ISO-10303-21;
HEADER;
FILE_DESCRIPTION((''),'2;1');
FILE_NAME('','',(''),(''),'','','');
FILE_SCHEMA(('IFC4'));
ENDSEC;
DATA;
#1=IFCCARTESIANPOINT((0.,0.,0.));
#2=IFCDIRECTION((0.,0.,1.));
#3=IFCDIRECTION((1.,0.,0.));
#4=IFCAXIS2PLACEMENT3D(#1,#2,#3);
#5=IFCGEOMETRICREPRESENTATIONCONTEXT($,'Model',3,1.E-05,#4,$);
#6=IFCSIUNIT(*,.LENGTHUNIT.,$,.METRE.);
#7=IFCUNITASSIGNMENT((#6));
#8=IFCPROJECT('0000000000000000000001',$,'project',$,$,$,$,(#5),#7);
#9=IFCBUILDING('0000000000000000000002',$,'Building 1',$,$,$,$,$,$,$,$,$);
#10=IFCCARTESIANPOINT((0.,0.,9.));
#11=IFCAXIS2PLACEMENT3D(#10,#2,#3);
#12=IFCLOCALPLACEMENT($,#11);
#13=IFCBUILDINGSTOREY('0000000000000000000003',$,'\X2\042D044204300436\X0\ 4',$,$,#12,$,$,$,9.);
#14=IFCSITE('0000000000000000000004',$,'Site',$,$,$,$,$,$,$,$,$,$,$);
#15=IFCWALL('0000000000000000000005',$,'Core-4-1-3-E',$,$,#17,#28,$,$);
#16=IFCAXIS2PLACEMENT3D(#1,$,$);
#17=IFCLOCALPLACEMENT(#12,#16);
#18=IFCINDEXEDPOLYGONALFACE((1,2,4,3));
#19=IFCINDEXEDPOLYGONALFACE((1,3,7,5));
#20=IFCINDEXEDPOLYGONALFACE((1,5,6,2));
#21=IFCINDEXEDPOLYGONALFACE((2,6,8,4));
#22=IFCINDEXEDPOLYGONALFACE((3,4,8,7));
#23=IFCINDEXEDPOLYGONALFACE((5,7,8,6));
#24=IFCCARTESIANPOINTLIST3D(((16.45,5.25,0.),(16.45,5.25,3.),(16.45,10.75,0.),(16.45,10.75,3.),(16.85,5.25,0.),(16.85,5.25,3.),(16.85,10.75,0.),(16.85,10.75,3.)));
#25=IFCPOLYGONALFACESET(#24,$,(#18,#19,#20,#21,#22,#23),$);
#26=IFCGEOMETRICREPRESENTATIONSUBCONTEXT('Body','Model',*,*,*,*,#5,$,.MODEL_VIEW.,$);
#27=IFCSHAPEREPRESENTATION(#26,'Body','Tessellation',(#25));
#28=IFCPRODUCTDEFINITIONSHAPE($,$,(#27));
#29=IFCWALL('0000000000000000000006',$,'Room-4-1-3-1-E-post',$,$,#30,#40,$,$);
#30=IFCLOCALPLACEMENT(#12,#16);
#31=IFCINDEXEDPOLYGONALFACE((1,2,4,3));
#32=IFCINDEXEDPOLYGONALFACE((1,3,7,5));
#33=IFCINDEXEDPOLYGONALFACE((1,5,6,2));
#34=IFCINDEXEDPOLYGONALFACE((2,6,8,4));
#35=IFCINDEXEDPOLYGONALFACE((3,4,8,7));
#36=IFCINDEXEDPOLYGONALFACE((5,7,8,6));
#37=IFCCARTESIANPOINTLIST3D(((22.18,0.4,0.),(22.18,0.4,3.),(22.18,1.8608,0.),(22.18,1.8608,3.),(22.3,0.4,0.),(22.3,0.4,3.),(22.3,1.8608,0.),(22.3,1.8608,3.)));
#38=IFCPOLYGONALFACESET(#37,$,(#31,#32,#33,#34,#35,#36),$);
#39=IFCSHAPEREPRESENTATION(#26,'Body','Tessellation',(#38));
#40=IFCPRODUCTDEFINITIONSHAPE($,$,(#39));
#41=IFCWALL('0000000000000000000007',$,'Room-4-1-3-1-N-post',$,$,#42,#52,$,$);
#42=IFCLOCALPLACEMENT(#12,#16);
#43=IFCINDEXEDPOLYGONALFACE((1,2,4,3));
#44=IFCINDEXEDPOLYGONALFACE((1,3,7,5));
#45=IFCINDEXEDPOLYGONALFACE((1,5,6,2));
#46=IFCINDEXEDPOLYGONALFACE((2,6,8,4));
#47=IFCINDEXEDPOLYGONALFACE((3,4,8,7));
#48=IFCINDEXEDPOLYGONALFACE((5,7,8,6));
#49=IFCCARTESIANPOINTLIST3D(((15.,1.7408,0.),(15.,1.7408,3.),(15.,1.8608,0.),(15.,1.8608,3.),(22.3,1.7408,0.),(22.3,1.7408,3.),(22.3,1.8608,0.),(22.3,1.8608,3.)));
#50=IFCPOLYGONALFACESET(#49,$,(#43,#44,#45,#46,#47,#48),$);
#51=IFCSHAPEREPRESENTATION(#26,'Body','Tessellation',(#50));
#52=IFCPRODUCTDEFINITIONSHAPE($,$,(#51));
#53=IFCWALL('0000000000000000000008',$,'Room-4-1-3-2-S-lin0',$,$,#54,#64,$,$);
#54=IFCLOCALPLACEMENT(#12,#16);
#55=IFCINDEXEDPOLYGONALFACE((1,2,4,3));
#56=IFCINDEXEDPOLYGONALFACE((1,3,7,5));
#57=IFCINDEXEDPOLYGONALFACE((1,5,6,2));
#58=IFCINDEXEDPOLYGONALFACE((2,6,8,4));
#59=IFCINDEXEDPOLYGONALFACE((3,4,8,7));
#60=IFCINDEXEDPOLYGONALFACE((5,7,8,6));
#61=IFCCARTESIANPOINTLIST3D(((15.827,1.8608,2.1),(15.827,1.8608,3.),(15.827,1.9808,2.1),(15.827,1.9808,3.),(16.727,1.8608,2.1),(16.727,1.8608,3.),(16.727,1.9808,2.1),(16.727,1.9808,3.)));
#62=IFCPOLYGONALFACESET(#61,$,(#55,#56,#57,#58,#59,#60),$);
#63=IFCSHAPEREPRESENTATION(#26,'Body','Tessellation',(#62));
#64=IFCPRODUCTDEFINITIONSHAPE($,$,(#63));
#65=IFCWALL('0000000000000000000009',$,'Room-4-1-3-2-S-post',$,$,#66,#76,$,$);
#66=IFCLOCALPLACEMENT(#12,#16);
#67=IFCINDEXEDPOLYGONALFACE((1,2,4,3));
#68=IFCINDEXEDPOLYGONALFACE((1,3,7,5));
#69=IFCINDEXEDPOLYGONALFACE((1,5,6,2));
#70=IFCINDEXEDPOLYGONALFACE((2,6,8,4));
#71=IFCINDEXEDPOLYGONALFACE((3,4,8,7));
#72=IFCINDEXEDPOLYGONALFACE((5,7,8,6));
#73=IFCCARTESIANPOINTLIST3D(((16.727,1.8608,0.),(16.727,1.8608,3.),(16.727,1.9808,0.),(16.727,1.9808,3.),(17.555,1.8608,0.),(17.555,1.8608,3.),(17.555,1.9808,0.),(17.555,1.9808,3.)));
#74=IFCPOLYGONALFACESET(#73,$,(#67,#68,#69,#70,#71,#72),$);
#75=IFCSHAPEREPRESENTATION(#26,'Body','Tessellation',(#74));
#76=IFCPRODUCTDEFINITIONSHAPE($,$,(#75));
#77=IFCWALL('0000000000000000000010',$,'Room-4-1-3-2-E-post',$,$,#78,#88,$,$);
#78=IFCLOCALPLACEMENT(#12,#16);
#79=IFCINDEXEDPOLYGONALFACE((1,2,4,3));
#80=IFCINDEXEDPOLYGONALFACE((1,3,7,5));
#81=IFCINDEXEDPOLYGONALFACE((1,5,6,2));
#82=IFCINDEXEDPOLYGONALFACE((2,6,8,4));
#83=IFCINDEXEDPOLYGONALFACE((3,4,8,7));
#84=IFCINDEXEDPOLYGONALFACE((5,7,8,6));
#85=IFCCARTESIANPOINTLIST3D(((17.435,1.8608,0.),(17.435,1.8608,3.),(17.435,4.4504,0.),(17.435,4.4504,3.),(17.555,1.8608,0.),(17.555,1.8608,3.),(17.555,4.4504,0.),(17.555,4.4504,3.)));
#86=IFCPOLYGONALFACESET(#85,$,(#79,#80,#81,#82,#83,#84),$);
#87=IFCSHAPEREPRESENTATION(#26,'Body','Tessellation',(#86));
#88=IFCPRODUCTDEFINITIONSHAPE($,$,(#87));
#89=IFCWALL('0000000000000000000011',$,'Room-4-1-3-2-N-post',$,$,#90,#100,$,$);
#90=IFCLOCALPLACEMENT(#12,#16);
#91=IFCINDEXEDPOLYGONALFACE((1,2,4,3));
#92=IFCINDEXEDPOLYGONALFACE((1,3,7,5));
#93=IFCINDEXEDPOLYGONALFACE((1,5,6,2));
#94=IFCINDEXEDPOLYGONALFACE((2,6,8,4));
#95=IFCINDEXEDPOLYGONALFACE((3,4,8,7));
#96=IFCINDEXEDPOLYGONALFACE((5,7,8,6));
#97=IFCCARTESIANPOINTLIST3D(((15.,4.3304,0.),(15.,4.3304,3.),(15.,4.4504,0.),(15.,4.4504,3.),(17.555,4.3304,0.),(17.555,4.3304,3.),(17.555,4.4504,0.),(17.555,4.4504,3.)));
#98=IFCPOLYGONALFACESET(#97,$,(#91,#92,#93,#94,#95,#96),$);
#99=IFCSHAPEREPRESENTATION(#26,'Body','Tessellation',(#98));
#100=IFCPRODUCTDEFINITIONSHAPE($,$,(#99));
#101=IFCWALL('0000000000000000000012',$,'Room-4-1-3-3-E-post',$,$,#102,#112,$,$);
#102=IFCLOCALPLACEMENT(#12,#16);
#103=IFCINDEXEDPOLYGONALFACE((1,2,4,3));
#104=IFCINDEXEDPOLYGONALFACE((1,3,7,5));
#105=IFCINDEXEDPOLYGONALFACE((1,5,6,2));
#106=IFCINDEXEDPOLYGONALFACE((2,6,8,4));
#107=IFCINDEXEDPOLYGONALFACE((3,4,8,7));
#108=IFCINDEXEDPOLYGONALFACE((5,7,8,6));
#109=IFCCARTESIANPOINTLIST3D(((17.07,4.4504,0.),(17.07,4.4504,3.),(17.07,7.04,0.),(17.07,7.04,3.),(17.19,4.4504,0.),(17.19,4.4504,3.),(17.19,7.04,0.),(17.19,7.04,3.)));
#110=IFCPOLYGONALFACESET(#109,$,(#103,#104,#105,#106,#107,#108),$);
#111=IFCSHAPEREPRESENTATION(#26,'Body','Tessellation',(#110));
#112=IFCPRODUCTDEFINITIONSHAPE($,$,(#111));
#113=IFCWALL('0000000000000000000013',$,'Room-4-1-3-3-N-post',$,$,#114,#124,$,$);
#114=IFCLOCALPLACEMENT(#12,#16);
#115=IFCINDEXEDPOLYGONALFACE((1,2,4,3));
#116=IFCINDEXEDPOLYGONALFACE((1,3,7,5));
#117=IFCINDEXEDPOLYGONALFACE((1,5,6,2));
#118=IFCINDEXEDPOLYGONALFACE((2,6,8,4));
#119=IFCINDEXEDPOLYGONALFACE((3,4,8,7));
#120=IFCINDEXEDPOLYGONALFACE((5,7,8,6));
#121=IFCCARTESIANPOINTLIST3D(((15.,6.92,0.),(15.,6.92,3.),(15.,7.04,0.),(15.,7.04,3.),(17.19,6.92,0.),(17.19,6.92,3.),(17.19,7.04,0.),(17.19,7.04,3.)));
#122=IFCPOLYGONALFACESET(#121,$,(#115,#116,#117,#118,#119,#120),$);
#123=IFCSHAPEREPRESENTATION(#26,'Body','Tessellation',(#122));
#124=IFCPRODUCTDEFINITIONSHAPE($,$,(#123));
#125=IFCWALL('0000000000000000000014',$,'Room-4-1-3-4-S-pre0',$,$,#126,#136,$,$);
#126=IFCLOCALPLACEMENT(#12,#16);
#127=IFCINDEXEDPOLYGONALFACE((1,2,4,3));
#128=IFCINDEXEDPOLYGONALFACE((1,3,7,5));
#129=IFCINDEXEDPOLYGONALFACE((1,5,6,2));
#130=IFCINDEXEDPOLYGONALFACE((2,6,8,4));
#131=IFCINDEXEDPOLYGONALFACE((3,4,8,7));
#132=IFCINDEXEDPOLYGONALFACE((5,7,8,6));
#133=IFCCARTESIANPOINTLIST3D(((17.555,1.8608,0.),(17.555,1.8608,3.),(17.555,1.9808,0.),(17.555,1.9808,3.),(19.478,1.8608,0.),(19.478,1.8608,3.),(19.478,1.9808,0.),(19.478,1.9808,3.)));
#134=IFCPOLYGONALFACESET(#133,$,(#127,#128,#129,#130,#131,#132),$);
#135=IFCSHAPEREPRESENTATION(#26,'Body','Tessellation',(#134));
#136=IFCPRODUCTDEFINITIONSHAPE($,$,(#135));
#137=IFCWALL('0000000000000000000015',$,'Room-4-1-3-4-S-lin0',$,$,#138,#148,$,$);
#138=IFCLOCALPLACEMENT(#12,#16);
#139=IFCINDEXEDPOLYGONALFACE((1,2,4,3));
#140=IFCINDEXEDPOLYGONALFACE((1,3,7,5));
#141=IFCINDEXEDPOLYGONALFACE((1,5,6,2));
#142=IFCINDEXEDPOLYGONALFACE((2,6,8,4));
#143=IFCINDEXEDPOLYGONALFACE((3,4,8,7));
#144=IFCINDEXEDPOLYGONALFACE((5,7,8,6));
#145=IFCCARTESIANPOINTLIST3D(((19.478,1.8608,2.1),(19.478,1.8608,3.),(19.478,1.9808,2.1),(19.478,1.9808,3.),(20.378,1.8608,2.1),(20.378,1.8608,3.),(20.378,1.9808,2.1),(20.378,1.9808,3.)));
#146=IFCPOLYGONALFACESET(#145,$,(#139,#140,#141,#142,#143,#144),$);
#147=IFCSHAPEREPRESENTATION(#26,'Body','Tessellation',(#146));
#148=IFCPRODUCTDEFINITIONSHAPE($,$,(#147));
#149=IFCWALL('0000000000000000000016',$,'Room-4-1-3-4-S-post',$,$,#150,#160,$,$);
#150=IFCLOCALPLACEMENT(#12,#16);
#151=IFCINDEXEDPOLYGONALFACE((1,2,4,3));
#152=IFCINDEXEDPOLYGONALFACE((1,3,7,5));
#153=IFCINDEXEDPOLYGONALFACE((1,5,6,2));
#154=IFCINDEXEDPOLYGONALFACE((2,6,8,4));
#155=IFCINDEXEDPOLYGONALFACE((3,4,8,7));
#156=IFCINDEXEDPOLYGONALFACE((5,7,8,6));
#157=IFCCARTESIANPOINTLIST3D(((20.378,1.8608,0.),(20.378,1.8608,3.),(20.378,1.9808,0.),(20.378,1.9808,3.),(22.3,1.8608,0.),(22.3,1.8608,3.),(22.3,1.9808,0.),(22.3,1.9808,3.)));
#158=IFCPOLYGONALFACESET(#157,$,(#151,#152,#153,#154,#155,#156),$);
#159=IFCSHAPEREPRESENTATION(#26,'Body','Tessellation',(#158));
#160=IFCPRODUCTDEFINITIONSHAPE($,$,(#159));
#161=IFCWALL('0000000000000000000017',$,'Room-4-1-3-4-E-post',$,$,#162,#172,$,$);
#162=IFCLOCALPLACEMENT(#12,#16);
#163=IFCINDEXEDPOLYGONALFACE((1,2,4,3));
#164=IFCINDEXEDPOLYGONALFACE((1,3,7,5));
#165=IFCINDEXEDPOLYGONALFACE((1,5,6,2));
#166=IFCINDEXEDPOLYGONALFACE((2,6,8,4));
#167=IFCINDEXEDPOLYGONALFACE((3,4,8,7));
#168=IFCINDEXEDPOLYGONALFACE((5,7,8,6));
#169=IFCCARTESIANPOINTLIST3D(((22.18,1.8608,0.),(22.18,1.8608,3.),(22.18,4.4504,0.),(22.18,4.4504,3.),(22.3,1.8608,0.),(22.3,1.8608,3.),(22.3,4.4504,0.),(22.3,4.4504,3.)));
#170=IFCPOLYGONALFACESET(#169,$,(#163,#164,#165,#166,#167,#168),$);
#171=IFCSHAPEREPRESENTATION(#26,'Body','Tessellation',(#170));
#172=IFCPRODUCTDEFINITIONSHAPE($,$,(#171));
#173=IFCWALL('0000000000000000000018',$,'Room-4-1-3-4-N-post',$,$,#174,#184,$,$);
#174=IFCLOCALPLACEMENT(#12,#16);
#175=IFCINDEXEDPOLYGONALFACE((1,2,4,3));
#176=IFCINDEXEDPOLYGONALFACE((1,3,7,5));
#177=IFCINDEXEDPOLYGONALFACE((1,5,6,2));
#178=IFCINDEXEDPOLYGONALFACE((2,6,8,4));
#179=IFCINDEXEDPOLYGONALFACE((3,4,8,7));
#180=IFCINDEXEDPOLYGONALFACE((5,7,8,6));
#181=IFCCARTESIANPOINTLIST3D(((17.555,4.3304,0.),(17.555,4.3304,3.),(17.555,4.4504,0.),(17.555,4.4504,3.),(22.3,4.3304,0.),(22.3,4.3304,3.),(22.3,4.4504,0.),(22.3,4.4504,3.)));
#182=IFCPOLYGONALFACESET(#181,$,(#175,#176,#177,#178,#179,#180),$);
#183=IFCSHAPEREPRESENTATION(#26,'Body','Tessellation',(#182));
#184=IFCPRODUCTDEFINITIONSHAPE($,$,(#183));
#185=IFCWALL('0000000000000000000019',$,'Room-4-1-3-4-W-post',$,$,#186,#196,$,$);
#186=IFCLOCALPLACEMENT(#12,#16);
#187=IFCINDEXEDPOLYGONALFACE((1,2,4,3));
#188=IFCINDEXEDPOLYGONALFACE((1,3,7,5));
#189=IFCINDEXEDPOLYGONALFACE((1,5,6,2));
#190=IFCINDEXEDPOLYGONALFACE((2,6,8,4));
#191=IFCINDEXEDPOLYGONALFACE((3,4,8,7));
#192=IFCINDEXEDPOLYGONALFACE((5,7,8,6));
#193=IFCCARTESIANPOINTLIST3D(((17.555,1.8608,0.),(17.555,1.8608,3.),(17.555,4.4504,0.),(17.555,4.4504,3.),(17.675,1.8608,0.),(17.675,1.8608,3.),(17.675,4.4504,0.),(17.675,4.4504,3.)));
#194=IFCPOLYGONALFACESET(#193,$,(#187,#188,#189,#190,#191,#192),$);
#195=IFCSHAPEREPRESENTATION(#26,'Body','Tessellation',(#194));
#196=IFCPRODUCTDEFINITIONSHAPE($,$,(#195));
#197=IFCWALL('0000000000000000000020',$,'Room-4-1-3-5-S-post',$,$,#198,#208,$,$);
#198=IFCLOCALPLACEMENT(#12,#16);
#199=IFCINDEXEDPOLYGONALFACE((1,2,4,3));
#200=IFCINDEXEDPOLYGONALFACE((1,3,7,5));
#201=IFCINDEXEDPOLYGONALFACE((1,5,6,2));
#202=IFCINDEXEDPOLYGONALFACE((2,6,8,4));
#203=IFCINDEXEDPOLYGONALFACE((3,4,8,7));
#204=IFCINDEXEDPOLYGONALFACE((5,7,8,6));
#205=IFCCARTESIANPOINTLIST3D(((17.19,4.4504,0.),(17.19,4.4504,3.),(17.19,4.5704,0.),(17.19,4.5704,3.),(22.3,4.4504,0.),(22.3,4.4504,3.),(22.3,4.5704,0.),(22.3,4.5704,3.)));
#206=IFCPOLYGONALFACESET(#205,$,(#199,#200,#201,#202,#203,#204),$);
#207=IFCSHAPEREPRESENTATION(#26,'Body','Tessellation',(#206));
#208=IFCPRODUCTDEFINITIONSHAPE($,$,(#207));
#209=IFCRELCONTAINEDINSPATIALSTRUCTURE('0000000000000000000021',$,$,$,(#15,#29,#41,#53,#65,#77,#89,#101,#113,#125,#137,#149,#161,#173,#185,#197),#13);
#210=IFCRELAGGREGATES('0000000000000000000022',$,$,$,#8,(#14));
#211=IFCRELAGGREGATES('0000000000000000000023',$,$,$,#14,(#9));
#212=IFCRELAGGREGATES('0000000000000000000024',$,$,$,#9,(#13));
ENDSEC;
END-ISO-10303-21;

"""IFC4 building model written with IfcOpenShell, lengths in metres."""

from ifc_helpers import new_model, si_unit, frame, origin_with_axes, place, context, subcontext, project, spatial, indexed_curve, outline, extrude, element, save


model = new_model("IFC4")

# Units and contexts
model_context = context("Model", 3, precision=1e-05, world=origin_with_axes())
body_context = subcontext(model_context, "Body", "Model", "MODEL_VIEW")
ifc_project = project(units=[si_unit("LENGTHUNIT", "METRE")], contexts=[model_context])

# Site, building, storey
site = spatial("IfcSite", under=ifc_project, Name="Site")
building = spatial("IfcBuilding", under=site, Name="Building 1")
storey_placement = place(None, frame((0.0, 0.0, 9.0), z_axis=(0.0, 0.0, 1.0), x_axis=(1.0, 0.0, 0.0)))
storey = spatial("IfcBuildingStorey", under=building, at=storey_placement, Name="Этаж 4", Elevation=9.0)

# Walls
wall_1_placement = place(storey_placement, frame((16.85, 5.25, 0.0), z_axis=(0.0, 0.0, 1.0), x_axis=(0.0, 1.0, 0.0)))
element("IfcWall", 1, at=wall_1_placement, inside=storey, Name="Core-4-1-3-E", context=body_context, shape_type="SweptSolid", body=[
    extrude(outline(indexed_curve([(0.0, 0.0), (0.0, 0.4), (5.5, 0.4), (5.5, 0.0), (0.0, 0.0)], self_intersect=False)), origin_with_axes(), (0.0, 0.0, 1.0), 3.0),
])
wall_2_placement = place(storey_placement, frame((22.3, 0.4, 0.0), z_axis=(0.0, 0.0, 1.0), x_axis=(0.0, 1.0, 0.0)))
element("IfcWall", 2, at=wall_2_placement, inside=storey, Name="Room-4-1-3-1-E-post", context=body_context, shape_type="SweptSolid", body=[
    extrude(outline(indexed_curve([(0.0, 0.0), (0.0, 0.12), (1.4608, 0.12), (1.4608, 0.0), (0.0, 0.0)], self_intersect=False)), origin_with_axes(), (0.0, 0.0, 1.0), 3.0),
])
wall_3_placement = place(storey_placement, frame((22.3, 1.8608, 0.0), z_axis=(0.0, 0.0, 1.0), x_axis=(-1.0, 0.0, 0.0)))
element("IfcWall", 3, at=wall_3_placement, inside=storey, Name="Room-4-1-3-1-N-post", context=body_context, shape_type="SweptSolid", body=[
    extrude(outline(indexed_curve([(0.0, 0.0), (0.0, 0.12), (7.3, 0.12), (7.3, 0.0), (0.0, 0.0)], self_intersect=False)), origin_with_axes(), (0.0, 0.0, 1.0), 3.0),
])
wall_4_placement = place(storey_placement, frame((15.827, 1.8608, 2.1), z_axis=(0.0, 0.0, 1.0), x_axis=(1.0, 0.0, 0.0)))
element("IfcWall", 4, at=wall_4_placement, inside=storey, Name="Room-4-1-3-2-S-lin0", context=body_context, shape_type="SweptSolid", body=[
    extrude(outline(indexed_curve([(0.0, 0.0), (0.0, 0.12), (0.9, 0.12), (0.9, 0.0), (0.0, 0.0)], self_intersect=False)), origin_with_axes(), (0.0, 0.0, 1.0), 0.9),
])
wall_5_placement = place(storey_placement, frame((16.727, 1.8608, 0.0), z_axis=(0.0, 0.0, 1.0), x_axis=(1.0, 0.0, 0.0)))
element("IfcWall", 5, at=wall_5_placement, inside=storey, Name="Room-4-1-3-2-S-post", context=body_context, shape_type="SweptSolid", body=[
    extrude(outline(indexed_curve([(0.0, 0.0), (0.0, 0.12), (0.828, 0.12), (0.828, 0.0), (0.0, 0.0)], self_intersect=False)), origin_with_axes(), (0.0, 0.0, 1.0), 3.0),
])
wall_6_placement = place(storey_placement, frame((17.555, 1.8608, 0.0), z_axis=(0.0, 0.0, 1.0), x_axis=(0.0, 1.0, 0.0)))
element("IfcWall", 6, at=wall_6_placement, inside=storey, Name="Room-4-1-3-2-E-post", context=body_context, shape_type="SweptSolid", body=[
    extrude(outline(indexed_curve([(0.0, 0.0), (0.0, 0.12), (2.5896, 0.12), (2.5896, 0.0), (0.0, 0.0)], self_intersect=False)), origin_with_axes(), (0.0, 0.0, 1.0), 3.0),
])
wall_7_placement = place(storey_placement, frame((17.555, 4.4504, 0.0), z_axis=(0.0, 0.0, 1.0), x_axis=(-1.0, 0.0, 0.0)))
element("IfcWall", 7, at=wall_7_placement, inside=storey, Name="Room-4-1-3-2-N-post", context=body_context, shape_type="SweptSolid", body=[
    extrude(outline(indexed_curve([(0.0, 0.0), (0.0, 0.12), (2.555, 0.12), (2.555, 0.0), (0.0, 0.0)], self_intersect=False)), origin_with_axes(), (0.0, 0.0, 1.0), 3.0),
])
wall_8_placement = place(storey_placement, frame((17.19, 4.4504, 0.0), z_axis=(0.0, 0.0, 1.0), x_axis=(0.0, 1.0, 0.0)))
element("IfcWall", 8, at=wall_8_placement, inside=storey, Name="Room-4-1-3-3-E-post", context=body_context, shape_type="SweptSolid", body=[
    extrude(outline(indexed_curve([(0.0, 0.0), (0.0, 0.12), (2.5896, 0.12), (2.5896, 0.0), (0.0, 0.0)], self_intersect=False)), origin_with_axes(), (0.0, 0.0, 1.0), 3.0),
])
wall_9_placement = place(storey_placement, frame((17.19, 7.04, 0.0), z_axis=(0.0, 0.0, 1.0), x_axis=(-1.0, 0.0, 0.0)))
element("IfcWall", 9, at=wall_9_placement, inside=storey, Name="Room-4-1-3-3-N-post", context=body_context, shape_type="SweptSolid", body=[
    extrude(outline(indexed_curve([(0.0, 0.0), (0.0, 0.12), (2.19, 0.12), (2.19, 0.0), (0.0, 0.0)], self_intersect=False)), origin_with_axes(), (0.0, 0.0, 1.0), 3.0),
])
wall_10_placement = place(storey_placement, frame((17.555, 1.8608, 0.0), z_axis=(0.0, 0.0, 1.0), x_axis=(1.0, 0.0, 0.0)))
element("IfcWall", 10, at=wall_10_placement, inside=storey, Name="Room-4-1-3-4-S-pre0", context=body_context, shape_type="SweptSolid", body=[
    extrude(outline(indexed_curve([(0.0, 0.0), (0.0, 0.12), (1.923, 0.12), (1.923, 0.0), (0.0, 0.0)], self_intersect=False)), origin_with_axes(), (0.0, 0.0, 1.0), 3.0),
])
wall_11_placement = place(storey_placement, frame((19.478, 1.8608, 2.1), z_axis=(0.0, 0.0, 1.0), x_axis=(1.0, 0.0, 0.0)))
element("IfcWall", 11, at=wall_11_placement, inside=storey, Name="Room-4-1-3-4-S-lin0", context=body_context, shape_type="SweptSolid", body=[
    extrude(outline(indexed_curve([(0.0, 0.0), (0.0, 0.12), (0.9, 0.12), (0.9, 0.0), (0.0, 0.0)], self_intersect=False)), origin_with_axes(), (0.0, 0.0, 1.0), 0.9),
])
wall_12_placement = place(storey_placement, frame((20.378, 1.8608, 0.0), z_axis=(0.0, 0.0, 1.0), x_axis=(1.0, 0.0, 0.0)))
element("IfcWall", 12, at=wall_12_placement, inside=storey, Name="Room-4-1-3-4-S-post", context=body_context, shape_type="SweptSolid", body=[
    extrude(outline(indexed_curve([(0.0, 0.0), (0.0, 0.12), (1.922, 0.12), (1.922, 0.0), (0.0, 0.0)], self_intersect=False)), origin_with_axes(), (0.0, 0.0, 1.0), 3.0),
])
wall_13_placement = place(storey_placement, frame((22.3, 1.8608, 0.0), z_axis=(0.0, 0.0, 1.0), x_axis=(0.0, 1.0, 0.0)))
element("IfcWall", 13, at=wall_13_placement, inside=storey, Name="Room-4-1-3-4-E-post", context=body_context, shape_type="SweptSolid", body=[
    extrude(outline(indexed_curve([(0.0, 0.0), (0.0, 0.12), (2.5896, 0.12), (2.5896, 0.0), (0.0, 0.0)], self_intersect=False)), origin_with_axes(), (0.0, 0.0, 1.0), 3.0),
])
wall_14_placement = place(storey_placement, frame((22.3, 4.4504, 0.0), z_axis=(0.0, 0.0, 1.0), x_axis=(-1.0, 0.0, 0.0)))
element("IfcWall", 14, at=wall_14_placement, inside=storey, Name="Room-4-1-3-4-N-post", context=body_context, shape_type="SweptSolid", body=[
    extrude(outline(indexed_curve([(0.0, 0.0), (0.0, 0.12), (4.745, 0.12), (4.745, 0.0), (0.0, 0.0)], self_intersect=False)), origin_with_axes(), (0.0, 0.0, 1.0), 3.0),
])
wall_15_placement = place(storey_placement, frame((17.555, 4.4504, 0.0), z_axis=(0.0, 0.0, 1.0), x_axis=(0.0, -1.0, 0.0)))
element("IfcWall", 15, at=wall_15_placement, inside=storey, Name="Room-4-1-3-4-W-post", context=body_context, shape_type="SweptSolid", body=[
    extrude(outline(indexed_curve([(0.0, 0.0), (0.0, 0.12), (2.5896, 0.12), (2.5896, 0.0), (0.0, 0.0)], self_intersect=False)), origin_with_axes(), (0.0, 0.0, 1.0), 3.0),
])
wall_16_placement = place(storey_placement, frame((17.19, 4.4504, 0.0), z_axis=(0.0, 0.0, 1.0), x_axis=(1.0, 0.0, 0.0)))
element("IfcWall", 16, at=wall_16_placement, inside=storey, Name="Room-4-1-3-5-S-post", context=body_context, shape_type="SweptSolid", body=[
    extrude(outline(indexed_curve([(0.0, 0.0), (0.0, 0.12), (5.11, 0.12), (5.11, 0.0), (0.0, 0.0)], self_intersect=False)), origin_with_axes(), (0.0, 0.0, 1.0), 3.0),
])

save(model, "model.ifc")
